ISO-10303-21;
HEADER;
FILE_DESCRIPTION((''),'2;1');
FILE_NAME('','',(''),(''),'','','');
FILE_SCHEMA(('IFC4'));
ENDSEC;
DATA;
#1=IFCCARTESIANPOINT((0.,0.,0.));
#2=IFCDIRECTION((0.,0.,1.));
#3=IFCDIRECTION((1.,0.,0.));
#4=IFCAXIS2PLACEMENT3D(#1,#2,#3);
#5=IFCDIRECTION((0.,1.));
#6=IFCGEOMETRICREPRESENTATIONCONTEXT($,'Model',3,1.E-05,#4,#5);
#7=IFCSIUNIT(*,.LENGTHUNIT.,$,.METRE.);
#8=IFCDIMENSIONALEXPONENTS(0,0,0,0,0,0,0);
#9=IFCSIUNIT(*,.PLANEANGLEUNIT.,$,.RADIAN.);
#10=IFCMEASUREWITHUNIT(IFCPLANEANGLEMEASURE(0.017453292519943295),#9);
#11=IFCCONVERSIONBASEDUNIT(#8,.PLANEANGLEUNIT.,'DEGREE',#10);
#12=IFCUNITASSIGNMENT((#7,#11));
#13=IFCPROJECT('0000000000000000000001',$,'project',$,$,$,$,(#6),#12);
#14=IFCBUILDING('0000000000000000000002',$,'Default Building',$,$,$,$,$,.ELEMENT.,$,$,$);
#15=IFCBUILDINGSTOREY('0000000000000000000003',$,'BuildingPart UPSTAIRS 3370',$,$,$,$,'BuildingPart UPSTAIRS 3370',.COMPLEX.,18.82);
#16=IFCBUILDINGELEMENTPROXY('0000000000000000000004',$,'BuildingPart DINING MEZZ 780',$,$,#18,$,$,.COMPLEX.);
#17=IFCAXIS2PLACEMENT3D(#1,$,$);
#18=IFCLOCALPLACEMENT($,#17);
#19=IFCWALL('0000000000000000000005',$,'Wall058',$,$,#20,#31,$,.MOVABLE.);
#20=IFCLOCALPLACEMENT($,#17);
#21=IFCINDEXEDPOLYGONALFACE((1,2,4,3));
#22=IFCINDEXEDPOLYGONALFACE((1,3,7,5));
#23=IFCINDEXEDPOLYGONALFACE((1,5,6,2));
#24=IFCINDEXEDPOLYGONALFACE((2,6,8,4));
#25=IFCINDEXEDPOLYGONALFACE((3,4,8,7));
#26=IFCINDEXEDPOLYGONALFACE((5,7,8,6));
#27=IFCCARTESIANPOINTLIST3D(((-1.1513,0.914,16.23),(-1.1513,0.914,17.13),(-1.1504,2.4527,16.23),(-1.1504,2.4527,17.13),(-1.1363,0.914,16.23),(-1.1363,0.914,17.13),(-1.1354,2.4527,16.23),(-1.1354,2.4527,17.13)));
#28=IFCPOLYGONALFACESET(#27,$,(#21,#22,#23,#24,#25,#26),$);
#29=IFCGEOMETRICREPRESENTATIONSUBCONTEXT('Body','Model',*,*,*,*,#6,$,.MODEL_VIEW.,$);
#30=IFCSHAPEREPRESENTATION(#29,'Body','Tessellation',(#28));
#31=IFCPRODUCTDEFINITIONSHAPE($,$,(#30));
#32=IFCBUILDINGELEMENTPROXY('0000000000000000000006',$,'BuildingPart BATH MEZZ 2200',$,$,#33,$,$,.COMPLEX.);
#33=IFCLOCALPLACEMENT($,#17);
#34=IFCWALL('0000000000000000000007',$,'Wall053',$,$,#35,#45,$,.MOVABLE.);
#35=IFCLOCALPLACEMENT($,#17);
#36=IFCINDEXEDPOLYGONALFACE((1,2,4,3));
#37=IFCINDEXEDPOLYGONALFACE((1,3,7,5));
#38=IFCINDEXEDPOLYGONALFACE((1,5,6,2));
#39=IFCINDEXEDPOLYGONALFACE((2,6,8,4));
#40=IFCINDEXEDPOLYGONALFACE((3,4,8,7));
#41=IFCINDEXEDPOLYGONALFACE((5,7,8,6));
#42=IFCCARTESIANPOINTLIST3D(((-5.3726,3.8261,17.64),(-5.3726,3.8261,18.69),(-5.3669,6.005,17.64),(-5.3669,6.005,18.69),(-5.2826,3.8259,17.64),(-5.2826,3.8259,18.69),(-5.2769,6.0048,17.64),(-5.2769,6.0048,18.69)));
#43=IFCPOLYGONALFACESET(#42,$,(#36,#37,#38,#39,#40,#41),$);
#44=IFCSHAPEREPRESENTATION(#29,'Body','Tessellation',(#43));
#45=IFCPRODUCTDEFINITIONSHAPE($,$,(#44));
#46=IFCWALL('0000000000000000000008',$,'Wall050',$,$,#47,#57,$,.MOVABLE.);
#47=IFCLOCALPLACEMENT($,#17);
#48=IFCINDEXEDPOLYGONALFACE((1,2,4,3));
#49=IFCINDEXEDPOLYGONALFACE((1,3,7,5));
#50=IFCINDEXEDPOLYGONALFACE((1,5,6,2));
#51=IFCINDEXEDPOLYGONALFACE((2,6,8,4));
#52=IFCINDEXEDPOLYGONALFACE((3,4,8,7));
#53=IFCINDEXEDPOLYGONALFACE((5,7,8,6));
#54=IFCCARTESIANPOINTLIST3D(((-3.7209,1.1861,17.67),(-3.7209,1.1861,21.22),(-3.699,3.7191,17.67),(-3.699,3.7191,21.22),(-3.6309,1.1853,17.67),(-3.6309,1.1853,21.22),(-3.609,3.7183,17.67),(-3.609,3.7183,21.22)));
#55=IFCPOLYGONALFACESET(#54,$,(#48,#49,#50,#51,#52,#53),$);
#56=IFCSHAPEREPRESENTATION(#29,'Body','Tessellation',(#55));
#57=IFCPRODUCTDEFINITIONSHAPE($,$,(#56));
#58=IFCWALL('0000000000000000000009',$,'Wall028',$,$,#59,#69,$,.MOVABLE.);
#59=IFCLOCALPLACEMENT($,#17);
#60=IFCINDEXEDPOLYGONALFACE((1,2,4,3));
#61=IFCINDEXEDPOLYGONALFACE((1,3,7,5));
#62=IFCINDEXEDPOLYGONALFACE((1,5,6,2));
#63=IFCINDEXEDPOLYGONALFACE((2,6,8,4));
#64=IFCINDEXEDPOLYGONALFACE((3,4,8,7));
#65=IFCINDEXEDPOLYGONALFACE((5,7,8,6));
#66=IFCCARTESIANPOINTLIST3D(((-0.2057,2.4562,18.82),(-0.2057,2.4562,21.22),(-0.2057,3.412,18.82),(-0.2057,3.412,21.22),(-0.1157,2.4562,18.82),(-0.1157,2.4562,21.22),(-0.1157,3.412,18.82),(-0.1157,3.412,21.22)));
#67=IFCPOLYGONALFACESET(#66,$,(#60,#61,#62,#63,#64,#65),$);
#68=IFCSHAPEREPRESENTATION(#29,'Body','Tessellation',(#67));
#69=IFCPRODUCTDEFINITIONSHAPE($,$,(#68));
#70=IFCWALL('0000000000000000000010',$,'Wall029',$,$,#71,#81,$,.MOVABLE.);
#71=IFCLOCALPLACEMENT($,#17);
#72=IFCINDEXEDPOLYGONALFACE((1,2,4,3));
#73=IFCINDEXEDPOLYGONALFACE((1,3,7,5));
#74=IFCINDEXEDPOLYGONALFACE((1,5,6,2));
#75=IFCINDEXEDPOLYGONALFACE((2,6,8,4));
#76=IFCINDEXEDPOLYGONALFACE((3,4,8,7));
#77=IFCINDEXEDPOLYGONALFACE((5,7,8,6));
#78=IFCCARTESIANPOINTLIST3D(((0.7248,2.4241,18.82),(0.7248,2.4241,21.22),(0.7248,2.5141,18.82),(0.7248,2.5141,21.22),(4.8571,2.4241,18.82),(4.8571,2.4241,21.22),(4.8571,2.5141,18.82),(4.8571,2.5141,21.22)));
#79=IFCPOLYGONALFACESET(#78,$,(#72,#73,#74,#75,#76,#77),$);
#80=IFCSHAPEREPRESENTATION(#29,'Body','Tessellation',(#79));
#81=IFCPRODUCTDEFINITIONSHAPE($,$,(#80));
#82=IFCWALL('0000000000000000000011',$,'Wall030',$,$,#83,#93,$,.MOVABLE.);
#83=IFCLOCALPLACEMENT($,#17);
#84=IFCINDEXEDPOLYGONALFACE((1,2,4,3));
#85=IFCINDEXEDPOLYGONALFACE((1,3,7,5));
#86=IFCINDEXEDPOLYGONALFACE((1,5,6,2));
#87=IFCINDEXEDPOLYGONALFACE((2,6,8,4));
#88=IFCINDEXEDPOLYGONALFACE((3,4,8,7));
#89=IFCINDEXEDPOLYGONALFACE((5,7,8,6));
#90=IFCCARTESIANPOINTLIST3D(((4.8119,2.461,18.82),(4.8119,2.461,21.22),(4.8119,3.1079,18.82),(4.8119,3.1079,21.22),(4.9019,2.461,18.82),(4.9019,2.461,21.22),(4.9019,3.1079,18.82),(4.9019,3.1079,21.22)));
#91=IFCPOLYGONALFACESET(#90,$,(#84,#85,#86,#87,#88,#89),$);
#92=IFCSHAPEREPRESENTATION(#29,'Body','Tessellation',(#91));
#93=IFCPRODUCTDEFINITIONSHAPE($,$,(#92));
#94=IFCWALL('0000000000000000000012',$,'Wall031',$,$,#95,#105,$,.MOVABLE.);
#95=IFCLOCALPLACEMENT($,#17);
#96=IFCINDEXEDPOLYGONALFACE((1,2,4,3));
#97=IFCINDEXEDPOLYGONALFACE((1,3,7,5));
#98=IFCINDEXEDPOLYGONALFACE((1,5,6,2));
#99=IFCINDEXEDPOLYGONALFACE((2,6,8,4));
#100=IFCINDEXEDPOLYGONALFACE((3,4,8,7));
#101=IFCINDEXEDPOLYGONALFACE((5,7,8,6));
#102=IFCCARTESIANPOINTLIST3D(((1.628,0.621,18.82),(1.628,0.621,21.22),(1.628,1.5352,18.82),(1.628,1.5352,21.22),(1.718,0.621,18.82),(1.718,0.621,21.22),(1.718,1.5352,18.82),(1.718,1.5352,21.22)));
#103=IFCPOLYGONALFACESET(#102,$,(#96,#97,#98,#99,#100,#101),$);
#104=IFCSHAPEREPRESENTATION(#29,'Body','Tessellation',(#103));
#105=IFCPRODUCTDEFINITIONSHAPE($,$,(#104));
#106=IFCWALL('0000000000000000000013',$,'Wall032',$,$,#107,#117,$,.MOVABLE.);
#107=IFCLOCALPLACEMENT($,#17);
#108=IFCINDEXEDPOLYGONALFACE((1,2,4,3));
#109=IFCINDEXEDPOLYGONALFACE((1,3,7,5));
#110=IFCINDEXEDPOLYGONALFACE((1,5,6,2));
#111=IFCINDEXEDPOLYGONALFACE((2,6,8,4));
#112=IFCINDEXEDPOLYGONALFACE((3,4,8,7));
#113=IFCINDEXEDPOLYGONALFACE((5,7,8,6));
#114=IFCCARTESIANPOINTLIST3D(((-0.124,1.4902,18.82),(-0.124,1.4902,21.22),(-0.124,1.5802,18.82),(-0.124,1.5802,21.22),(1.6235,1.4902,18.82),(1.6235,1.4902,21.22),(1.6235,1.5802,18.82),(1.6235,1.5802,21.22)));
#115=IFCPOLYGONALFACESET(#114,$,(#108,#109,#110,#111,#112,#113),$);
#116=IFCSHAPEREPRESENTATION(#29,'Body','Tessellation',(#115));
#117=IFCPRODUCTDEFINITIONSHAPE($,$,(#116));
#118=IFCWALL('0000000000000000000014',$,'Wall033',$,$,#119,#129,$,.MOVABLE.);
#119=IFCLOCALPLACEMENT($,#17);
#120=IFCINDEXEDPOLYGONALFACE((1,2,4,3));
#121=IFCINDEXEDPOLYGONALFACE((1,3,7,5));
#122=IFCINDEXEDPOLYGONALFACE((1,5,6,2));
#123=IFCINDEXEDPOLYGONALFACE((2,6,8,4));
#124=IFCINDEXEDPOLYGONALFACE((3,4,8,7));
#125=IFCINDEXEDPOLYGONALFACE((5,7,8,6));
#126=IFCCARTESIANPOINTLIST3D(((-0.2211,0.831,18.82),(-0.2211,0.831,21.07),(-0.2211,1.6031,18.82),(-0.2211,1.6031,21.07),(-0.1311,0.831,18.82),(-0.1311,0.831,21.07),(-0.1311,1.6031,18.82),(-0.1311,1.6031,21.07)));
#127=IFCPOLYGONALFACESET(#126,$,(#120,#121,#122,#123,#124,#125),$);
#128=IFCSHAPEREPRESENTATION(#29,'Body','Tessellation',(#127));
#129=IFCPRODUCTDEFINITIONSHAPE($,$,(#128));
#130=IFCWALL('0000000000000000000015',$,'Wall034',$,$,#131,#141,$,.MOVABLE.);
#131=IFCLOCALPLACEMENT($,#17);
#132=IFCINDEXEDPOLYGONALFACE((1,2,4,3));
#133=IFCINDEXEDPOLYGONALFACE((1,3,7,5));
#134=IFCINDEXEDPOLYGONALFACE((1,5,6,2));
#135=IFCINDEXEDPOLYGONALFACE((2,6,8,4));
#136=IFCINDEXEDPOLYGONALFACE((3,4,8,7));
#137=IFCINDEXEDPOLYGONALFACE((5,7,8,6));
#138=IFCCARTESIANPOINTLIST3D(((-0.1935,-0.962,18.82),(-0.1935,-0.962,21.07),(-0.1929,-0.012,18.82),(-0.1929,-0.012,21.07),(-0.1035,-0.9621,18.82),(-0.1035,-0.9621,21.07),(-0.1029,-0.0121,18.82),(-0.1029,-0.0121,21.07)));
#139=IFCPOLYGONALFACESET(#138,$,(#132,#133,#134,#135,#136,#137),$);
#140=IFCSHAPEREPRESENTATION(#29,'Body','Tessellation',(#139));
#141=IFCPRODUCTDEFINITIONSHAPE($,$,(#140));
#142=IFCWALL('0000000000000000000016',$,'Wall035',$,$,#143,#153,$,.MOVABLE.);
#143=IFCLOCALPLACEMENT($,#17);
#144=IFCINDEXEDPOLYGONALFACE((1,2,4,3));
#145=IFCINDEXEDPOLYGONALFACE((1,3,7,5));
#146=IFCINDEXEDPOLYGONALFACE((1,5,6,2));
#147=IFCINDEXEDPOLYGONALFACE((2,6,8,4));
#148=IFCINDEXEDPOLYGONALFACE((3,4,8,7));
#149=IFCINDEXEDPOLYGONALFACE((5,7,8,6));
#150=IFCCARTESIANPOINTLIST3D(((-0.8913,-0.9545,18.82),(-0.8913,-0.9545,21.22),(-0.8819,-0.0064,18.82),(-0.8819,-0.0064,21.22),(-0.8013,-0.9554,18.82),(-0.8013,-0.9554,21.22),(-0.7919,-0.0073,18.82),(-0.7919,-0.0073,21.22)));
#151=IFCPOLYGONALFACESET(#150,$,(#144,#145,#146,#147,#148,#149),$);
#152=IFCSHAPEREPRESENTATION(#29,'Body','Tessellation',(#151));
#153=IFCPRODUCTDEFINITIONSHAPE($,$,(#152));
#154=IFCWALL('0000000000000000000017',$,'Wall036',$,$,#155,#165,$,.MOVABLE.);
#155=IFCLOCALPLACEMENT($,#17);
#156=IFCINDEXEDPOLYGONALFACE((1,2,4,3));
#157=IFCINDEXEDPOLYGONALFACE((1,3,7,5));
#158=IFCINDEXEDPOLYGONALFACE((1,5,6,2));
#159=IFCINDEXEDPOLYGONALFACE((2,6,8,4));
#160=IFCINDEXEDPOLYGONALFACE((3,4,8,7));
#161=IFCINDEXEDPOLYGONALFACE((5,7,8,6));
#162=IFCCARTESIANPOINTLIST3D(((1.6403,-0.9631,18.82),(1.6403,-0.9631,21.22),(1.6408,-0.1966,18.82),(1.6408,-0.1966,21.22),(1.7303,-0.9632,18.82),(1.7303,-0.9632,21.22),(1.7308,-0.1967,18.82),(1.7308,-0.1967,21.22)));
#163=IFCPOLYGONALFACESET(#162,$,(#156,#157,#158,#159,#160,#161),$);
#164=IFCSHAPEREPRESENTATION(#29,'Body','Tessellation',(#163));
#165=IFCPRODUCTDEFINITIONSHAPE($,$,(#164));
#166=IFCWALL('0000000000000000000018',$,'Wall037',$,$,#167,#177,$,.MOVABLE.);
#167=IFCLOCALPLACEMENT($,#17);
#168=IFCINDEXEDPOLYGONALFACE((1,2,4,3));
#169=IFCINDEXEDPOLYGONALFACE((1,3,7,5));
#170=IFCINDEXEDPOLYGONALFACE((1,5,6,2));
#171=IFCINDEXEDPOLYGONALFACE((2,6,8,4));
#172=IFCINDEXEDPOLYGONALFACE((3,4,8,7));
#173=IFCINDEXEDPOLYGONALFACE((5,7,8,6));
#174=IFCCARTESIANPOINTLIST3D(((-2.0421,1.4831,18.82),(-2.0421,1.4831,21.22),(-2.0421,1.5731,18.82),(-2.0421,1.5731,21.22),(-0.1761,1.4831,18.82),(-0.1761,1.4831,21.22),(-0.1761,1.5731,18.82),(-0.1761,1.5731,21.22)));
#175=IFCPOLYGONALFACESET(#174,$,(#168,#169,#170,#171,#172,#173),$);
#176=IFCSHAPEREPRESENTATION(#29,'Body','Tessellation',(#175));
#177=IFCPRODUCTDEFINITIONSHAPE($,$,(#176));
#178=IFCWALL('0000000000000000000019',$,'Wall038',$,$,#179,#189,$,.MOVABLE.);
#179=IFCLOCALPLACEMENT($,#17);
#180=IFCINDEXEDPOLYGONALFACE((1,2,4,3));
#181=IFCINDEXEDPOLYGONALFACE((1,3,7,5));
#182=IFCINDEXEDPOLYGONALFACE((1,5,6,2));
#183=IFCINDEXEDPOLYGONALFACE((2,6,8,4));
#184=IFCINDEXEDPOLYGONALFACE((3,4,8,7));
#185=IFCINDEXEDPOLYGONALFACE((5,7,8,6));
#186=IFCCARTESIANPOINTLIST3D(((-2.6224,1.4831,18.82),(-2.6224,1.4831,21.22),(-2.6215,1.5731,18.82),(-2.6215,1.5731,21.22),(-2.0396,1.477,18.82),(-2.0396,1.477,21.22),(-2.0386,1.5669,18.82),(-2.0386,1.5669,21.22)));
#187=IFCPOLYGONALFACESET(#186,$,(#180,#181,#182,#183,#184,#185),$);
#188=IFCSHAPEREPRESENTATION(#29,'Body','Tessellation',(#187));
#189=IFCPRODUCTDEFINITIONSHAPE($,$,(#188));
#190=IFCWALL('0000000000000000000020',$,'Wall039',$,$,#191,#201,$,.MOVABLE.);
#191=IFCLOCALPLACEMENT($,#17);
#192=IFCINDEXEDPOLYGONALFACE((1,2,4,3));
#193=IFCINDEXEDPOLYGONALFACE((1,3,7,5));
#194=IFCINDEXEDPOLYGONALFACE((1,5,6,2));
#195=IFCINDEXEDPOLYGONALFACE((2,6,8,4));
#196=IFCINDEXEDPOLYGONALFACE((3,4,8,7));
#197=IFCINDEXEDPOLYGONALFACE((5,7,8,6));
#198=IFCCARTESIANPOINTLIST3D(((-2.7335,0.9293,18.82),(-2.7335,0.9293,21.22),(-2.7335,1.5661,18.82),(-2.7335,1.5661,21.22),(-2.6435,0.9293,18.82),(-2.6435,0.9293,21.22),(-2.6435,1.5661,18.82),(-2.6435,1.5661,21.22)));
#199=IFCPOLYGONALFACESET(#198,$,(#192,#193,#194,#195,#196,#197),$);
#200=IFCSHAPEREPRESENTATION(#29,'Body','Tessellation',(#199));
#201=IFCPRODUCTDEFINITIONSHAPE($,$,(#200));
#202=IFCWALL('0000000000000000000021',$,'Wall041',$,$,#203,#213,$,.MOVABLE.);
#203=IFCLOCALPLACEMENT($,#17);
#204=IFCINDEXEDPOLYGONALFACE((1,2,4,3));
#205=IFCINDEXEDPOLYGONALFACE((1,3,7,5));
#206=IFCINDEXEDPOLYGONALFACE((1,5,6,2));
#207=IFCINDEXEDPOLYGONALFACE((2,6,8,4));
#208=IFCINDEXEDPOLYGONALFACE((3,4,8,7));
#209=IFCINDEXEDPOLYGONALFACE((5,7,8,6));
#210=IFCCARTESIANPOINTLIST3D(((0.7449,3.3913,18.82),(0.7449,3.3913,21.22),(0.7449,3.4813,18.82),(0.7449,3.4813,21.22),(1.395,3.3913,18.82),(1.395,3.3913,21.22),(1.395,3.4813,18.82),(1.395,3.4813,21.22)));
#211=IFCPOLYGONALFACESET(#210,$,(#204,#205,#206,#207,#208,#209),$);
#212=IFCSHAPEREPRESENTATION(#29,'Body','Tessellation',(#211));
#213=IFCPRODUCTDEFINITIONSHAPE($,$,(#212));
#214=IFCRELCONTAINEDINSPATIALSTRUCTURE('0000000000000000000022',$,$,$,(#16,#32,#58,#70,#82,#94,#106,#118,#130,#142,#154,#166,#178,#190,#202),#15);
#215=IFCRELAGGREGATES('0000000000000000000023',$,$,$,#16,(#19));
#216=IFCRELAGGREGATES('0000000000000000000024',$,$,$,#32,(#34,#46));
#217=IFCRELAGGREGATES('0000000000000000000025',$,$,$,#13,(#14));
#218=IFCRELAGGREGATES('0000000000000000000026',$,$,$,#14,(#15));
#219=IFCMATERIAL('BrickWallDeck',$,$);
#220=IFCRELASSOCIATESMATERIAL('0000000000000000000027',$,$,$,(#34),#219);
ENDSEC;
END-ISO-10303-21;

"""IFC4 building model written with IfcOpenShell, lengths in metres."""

from ifc_helpers import new_model, entity, si_unit, converted_unit, direction, frame, frame_2d, origin_with_axes, origin_2d_with_axis, place, context, subcontext, project, spatial, rectangle, extrude, material, element, aggregate, save


model = new_model("IFC4")

# Units and contexts
model_context = context("Model", 3, precision=1e-05, world=origin_with_axes(), true_north=direction((0.0, 1.0)))
body_context = subcontext(model_context, "Body", "Model", "MODEL_VIEW")
ifc_project = project(units=[si_unit("LENGTHUNIT", "METRE"), converted_unit("PLANEANGLEUNIT", "DEGREE", entity("IfcPlaneAngleMeasure", 0.017453292519943295), si_unit("PLANEANGLEUNIT", "RADIAN"), dimensions=[0, 0, 0, 0, 0, 0, 0])], contexts=[model_context])

# Building, storey
building = spatial("IfcBuilding", under=ifc_project, Name="Default Building", CompositionType="ELEMENT")
storey = spatial("IfcBuildingStorey", under=building, Name="BuildingPart UPSTAIRS 3370", LongName="BuildingPart UPSTAIRS 3370", CompositionType="COMPLEX", Elevation=18.82)

# Building element proxy, wall
proxy_1 = element("IfcBuildingElementProxy", 1, inside=storey, Name="BuildingPart DINING MEZZ 780", PredefinedType="COMPLEX")
placement = place(None, origin_with_axes())
wall_1 = element("IfcWall", 2, at=placement, Name="Wall058", PredefinedType="MOVABLE", context=body_context, shape_type="SweptSolid", body=[
    extrude(rectangle(XDim=1.5387, YDim=0.015, at=frame_2d((0.0, 0.0), x_axis=(0.000537, 1.0))), frame((-1.1433, 1.6834, 16.23), z_axis=(0.0, 0.0, 1.0), x_axis=(1.0, 0.0, 0.0)), (0.0, 0.0, 1.0), 0.9),
])

# Building element proxy, walls
proxy_2 = element("IfcBuildingElementProxy", 3, inside=storey, Name="BuildingPart BATH MEZZ 2200", PredefinedType="COMPLEX")
ifc_material_1 = material(Name="BrickWallDeck")
wall_2 = element("IfcWall", 4, at=placement, material=ifc_material_1, Name="Wall053", PredefinedType="MOVABLE", context=body_context, shape_type="SweptSolid", body=[
    extrude(rectangle(XDim=2.1789, YDim=0.09, at=frame_2d((0.0, 0.0), x_axis=(-0.002578, -0.999997))), frame((-5.3247, 4.9154, 17.64), z_axis=(0.0, 0.0, 1.0), x_axis=(1.0, 0.0, 0.0)), (0.0, 0.0, 1.0), 1.05),
])
wall_3 = element("IfcWall", 5, at=placement, Name="Wall050", PredefinedType="MOVABLE", context=body_context, shape_type="SweptSolid", body=[
    extrude(rectangle(XDim=2.5331, YDim=0.09, at=frame_2d((0.0, 0.0), x_axis=(-0.008658, -0.999963))), frame((-3.665, 2.4522, 17.67), z_axis=(0.0, 0.0, 1.0), x_axis=(1.0, 0.0, 0.0)), (0.0, 0.0, 1.0), 3.55),
])

# Walls
element("IfcWall", 6, at=placement, inside=storey, Name="Wall028", PredefinedType="MOVABLE", context=body_context, shape_type="SweptSolid", body=[
    extrude(rectangle(XDim=0.9557, YDim=0.09, at=frame_2d((0.0, 0.0), x_axis=(0.0, 1.0))), frame((-0.1607, 2.9341, 18.82), z_axis=(0.0, 0.0, 1.0), x_axis=(1.0, 0.0, 0.0)), (0.0, 0.0, 1.0), 2.4),
])
element("IfcWall", 7, at=placement, inside=storey, Name="Wall029", PredefinedType="MOVABLE", context=body_context, shape_type="SweptSolid", body=[
    extrude(rectangle(XDim=4.1323, YDim=0.09, at=origin_2d_with_axis()), frame((2.791, 2.4691, 18.82), z_axis=(0.0, 0.0, 1.0), x_axis=(1.0, 0.0, 0.0)), (0.0, 0.0, 1.0), 2.4),
])
element("IfcWall", 8, at=placement, inside=storey, Name="Wall030", PredefinedType="MOVABLE", context=body_context, shape_type="SweptSolid", body=[
    extrude(rectangle(XDim=0.6469, YDim=0.09, at=frame_2d((0.0, 0.0), x_axis=(0.0, 1.0))), frame((4.8569, 2.7845, 18.82), z_axis=(0.0, 0.0, 1.0), x_axis=(1.0, 0.0, 0.0)), (0.0, 0.0, 1.0), 2.4),
])
element("IfcWall", 9, at=placement, inside=storey, Name="Wall031", PredefinedType="MOVABLE", context=body_context, shape_type="SweptSolid", body=[
    extrude(rectangle(XDim=0.9143, YDim=0.09, at=frame_2d((0.0, 0.0), x_axis=(0.0, 1.0))), frame((1.673, 1.0781, 18.82), z_axis=(0.0, 0.0, 1.0), x_axis=(1.0, 0.0, 0.0)), (0.0, 0.0, 1.0), 2.4),
])
element("IfcWall", 10, at=placement, inside=storey, Name="Wall032", PredefinedType="MOVABLE", context=body_context, shape_type="SweptSolid", body=[
    extrude(rectangle(XDim=1.7475, YDim=0.09, at=origin_2d_with_axis()), frame((0.7498, 1.5352, 18.82), z_axis=(0.0, 0.0, 1.0), x_axis=(1.0, 0.0, 0.0)), (0.0, 0.0, 1.0), 2.4),
])
element("IfcWall", 11, at=placement, inside=storey, Name="Wall033", PredefinedType="MOVABLE", context=body_context, shape_type="SweptSolid", body=[
    extrude(rectangle(XDim=0.772, YDim=0.09, at=frame_2d((0.0, 0.0), x_axis=(0.0, 1.0))), frame((-0.1761, 1.217, 18.82), z_axis=(0.0, 0.0, 1.0), x_axis=(1.0, 0.0, 0.0)), (0.0, 0.0, 1.0), 2.25),
])
element("IfcWall", 12, at=placement, inside=storey, Name="Wall034", PredefinedType="MOVABLE", context=body_context, shape_type="SweptSolid", body=[
    extrude(rectangle(XDim=0.95, YDim=0.09, at=frame_2d((0.0, 0.0), x_axis=(-0.000602, -1.0))), frame((-0.1482, -0.487, 18.82), z_axis=(0.0, 0.0, 1.0), x_axis=(1.0, 0.0, 0.0)), (0.0, 0.0, 1.0), 2.25),
])
element("IfcWall", 13, at=placement, inside=storey, Name="Wall035", PredefinedType="MOVABLE", context=body_context, shape_type="SweptSolid", body=[
    extrude(rectangle(XDim=0.9481, YDim=0.09, at=frame_2d((0.0, 0.0), x_axis=(-0.009852, -0.999951))), frame((-0.8416, -0.4809, 18.82), z_axis=(0.0, 0.0, 1.0), x_axis=(1.0, 0.0, 0.0)), (0.0, 0.0, 1.0), 2.4),
])
element("IfcWall", 14, at=placement, inside=storey, Name="Wall036", PredefinedType="MOVABLE", context=body_context, shape_type="SweptSolid", body=[
    extrude(rectangle(XDim=0.7665, YDim=0.09, at=frame_2d((0.0, 0.0), x_axis=(-0.000602, -1.0))), frame((1.6856, -0.5799, 18.82), z_axis=(0.0, 0.0, 1.0), x_axis=(1.0, 0.0, 0.0)), (0.0, 0.0, 1.0), 2.4),
])
element("IfcWall", 15, at=placement, inside=storey, Name="Wall037", PredefinedType="MOVABLE", context=body_context, shape_type="SweptSolid", body=[
    extrude(rectangle(XDim=1.866, YDim=0.09, at=origin_2d_with_axis()), frame((-1.1091, 1.5281, 18.82), z_axis=(0.0, 0.0, 1.0), x_axis=(1.0, 0.0, 0.0)), (0.0, 0.0, 1.0), 2.4),
])
element("IfcWall", 16, at=placement, inside=storey, Name="Wall038", PredefinedType="MOVABLE", context=body_context, shape_type="SweptSolid", body=[
    extrude(rectangle(XDim=0.5828, YDim=0.09, at=frame_2d((0.0, 0.0), x_axis=(0.999944, -0.010593))), frame((-2.3305, 1.525, 18.82), z_axis=(0.0, 0.0, 1.0), x_axis=(1.0, 0.0, 0.0)), (0.0, 0.0, 1.0), 2.4),
])
element("IfcWall", 17, at=placement, inside=storey, Name="Wall039", PredefinedType="MOVABLE", context=body_context, shape_type="SweptSolid", body=[
    extrude(rectangle(XDim=0.6368, YDim=0.09, at=frame_2d((0.0, 0.0), x_axis=(0.0, 1.0))), frame((-2.6885, 1.2477, 18.82), z_axis=(0.0, 0.0, 1.0), x_axis=(1.0, 0.0, 0.0)), (0.0, 0.0, 1.0), 2.4),
])
element("IfcWall", 18, at=placement, inside=storey, Name="Wall041", PredefinedType="MOVABLE", context=body_context, shape_type="SweptSolid", body=[
    extrude(rectangle(XDim=0.6501, YDim=0.09, at=frame_2d((0.0, 0.0), x_axis=(-1.0, 0.0))), frame((1.07, 3.4363, 18.82), z_axis=(0.0, 0.0, 1.0), x_axis=(1.0, 0.0, 0.0)), (0.0, 0.0, 1.0), 2.4),
])

aggregate(proxy_1, [wall_1])
aggregate(proxy_2, [wall_2, wall_3])

save(model, "model.ifc")
